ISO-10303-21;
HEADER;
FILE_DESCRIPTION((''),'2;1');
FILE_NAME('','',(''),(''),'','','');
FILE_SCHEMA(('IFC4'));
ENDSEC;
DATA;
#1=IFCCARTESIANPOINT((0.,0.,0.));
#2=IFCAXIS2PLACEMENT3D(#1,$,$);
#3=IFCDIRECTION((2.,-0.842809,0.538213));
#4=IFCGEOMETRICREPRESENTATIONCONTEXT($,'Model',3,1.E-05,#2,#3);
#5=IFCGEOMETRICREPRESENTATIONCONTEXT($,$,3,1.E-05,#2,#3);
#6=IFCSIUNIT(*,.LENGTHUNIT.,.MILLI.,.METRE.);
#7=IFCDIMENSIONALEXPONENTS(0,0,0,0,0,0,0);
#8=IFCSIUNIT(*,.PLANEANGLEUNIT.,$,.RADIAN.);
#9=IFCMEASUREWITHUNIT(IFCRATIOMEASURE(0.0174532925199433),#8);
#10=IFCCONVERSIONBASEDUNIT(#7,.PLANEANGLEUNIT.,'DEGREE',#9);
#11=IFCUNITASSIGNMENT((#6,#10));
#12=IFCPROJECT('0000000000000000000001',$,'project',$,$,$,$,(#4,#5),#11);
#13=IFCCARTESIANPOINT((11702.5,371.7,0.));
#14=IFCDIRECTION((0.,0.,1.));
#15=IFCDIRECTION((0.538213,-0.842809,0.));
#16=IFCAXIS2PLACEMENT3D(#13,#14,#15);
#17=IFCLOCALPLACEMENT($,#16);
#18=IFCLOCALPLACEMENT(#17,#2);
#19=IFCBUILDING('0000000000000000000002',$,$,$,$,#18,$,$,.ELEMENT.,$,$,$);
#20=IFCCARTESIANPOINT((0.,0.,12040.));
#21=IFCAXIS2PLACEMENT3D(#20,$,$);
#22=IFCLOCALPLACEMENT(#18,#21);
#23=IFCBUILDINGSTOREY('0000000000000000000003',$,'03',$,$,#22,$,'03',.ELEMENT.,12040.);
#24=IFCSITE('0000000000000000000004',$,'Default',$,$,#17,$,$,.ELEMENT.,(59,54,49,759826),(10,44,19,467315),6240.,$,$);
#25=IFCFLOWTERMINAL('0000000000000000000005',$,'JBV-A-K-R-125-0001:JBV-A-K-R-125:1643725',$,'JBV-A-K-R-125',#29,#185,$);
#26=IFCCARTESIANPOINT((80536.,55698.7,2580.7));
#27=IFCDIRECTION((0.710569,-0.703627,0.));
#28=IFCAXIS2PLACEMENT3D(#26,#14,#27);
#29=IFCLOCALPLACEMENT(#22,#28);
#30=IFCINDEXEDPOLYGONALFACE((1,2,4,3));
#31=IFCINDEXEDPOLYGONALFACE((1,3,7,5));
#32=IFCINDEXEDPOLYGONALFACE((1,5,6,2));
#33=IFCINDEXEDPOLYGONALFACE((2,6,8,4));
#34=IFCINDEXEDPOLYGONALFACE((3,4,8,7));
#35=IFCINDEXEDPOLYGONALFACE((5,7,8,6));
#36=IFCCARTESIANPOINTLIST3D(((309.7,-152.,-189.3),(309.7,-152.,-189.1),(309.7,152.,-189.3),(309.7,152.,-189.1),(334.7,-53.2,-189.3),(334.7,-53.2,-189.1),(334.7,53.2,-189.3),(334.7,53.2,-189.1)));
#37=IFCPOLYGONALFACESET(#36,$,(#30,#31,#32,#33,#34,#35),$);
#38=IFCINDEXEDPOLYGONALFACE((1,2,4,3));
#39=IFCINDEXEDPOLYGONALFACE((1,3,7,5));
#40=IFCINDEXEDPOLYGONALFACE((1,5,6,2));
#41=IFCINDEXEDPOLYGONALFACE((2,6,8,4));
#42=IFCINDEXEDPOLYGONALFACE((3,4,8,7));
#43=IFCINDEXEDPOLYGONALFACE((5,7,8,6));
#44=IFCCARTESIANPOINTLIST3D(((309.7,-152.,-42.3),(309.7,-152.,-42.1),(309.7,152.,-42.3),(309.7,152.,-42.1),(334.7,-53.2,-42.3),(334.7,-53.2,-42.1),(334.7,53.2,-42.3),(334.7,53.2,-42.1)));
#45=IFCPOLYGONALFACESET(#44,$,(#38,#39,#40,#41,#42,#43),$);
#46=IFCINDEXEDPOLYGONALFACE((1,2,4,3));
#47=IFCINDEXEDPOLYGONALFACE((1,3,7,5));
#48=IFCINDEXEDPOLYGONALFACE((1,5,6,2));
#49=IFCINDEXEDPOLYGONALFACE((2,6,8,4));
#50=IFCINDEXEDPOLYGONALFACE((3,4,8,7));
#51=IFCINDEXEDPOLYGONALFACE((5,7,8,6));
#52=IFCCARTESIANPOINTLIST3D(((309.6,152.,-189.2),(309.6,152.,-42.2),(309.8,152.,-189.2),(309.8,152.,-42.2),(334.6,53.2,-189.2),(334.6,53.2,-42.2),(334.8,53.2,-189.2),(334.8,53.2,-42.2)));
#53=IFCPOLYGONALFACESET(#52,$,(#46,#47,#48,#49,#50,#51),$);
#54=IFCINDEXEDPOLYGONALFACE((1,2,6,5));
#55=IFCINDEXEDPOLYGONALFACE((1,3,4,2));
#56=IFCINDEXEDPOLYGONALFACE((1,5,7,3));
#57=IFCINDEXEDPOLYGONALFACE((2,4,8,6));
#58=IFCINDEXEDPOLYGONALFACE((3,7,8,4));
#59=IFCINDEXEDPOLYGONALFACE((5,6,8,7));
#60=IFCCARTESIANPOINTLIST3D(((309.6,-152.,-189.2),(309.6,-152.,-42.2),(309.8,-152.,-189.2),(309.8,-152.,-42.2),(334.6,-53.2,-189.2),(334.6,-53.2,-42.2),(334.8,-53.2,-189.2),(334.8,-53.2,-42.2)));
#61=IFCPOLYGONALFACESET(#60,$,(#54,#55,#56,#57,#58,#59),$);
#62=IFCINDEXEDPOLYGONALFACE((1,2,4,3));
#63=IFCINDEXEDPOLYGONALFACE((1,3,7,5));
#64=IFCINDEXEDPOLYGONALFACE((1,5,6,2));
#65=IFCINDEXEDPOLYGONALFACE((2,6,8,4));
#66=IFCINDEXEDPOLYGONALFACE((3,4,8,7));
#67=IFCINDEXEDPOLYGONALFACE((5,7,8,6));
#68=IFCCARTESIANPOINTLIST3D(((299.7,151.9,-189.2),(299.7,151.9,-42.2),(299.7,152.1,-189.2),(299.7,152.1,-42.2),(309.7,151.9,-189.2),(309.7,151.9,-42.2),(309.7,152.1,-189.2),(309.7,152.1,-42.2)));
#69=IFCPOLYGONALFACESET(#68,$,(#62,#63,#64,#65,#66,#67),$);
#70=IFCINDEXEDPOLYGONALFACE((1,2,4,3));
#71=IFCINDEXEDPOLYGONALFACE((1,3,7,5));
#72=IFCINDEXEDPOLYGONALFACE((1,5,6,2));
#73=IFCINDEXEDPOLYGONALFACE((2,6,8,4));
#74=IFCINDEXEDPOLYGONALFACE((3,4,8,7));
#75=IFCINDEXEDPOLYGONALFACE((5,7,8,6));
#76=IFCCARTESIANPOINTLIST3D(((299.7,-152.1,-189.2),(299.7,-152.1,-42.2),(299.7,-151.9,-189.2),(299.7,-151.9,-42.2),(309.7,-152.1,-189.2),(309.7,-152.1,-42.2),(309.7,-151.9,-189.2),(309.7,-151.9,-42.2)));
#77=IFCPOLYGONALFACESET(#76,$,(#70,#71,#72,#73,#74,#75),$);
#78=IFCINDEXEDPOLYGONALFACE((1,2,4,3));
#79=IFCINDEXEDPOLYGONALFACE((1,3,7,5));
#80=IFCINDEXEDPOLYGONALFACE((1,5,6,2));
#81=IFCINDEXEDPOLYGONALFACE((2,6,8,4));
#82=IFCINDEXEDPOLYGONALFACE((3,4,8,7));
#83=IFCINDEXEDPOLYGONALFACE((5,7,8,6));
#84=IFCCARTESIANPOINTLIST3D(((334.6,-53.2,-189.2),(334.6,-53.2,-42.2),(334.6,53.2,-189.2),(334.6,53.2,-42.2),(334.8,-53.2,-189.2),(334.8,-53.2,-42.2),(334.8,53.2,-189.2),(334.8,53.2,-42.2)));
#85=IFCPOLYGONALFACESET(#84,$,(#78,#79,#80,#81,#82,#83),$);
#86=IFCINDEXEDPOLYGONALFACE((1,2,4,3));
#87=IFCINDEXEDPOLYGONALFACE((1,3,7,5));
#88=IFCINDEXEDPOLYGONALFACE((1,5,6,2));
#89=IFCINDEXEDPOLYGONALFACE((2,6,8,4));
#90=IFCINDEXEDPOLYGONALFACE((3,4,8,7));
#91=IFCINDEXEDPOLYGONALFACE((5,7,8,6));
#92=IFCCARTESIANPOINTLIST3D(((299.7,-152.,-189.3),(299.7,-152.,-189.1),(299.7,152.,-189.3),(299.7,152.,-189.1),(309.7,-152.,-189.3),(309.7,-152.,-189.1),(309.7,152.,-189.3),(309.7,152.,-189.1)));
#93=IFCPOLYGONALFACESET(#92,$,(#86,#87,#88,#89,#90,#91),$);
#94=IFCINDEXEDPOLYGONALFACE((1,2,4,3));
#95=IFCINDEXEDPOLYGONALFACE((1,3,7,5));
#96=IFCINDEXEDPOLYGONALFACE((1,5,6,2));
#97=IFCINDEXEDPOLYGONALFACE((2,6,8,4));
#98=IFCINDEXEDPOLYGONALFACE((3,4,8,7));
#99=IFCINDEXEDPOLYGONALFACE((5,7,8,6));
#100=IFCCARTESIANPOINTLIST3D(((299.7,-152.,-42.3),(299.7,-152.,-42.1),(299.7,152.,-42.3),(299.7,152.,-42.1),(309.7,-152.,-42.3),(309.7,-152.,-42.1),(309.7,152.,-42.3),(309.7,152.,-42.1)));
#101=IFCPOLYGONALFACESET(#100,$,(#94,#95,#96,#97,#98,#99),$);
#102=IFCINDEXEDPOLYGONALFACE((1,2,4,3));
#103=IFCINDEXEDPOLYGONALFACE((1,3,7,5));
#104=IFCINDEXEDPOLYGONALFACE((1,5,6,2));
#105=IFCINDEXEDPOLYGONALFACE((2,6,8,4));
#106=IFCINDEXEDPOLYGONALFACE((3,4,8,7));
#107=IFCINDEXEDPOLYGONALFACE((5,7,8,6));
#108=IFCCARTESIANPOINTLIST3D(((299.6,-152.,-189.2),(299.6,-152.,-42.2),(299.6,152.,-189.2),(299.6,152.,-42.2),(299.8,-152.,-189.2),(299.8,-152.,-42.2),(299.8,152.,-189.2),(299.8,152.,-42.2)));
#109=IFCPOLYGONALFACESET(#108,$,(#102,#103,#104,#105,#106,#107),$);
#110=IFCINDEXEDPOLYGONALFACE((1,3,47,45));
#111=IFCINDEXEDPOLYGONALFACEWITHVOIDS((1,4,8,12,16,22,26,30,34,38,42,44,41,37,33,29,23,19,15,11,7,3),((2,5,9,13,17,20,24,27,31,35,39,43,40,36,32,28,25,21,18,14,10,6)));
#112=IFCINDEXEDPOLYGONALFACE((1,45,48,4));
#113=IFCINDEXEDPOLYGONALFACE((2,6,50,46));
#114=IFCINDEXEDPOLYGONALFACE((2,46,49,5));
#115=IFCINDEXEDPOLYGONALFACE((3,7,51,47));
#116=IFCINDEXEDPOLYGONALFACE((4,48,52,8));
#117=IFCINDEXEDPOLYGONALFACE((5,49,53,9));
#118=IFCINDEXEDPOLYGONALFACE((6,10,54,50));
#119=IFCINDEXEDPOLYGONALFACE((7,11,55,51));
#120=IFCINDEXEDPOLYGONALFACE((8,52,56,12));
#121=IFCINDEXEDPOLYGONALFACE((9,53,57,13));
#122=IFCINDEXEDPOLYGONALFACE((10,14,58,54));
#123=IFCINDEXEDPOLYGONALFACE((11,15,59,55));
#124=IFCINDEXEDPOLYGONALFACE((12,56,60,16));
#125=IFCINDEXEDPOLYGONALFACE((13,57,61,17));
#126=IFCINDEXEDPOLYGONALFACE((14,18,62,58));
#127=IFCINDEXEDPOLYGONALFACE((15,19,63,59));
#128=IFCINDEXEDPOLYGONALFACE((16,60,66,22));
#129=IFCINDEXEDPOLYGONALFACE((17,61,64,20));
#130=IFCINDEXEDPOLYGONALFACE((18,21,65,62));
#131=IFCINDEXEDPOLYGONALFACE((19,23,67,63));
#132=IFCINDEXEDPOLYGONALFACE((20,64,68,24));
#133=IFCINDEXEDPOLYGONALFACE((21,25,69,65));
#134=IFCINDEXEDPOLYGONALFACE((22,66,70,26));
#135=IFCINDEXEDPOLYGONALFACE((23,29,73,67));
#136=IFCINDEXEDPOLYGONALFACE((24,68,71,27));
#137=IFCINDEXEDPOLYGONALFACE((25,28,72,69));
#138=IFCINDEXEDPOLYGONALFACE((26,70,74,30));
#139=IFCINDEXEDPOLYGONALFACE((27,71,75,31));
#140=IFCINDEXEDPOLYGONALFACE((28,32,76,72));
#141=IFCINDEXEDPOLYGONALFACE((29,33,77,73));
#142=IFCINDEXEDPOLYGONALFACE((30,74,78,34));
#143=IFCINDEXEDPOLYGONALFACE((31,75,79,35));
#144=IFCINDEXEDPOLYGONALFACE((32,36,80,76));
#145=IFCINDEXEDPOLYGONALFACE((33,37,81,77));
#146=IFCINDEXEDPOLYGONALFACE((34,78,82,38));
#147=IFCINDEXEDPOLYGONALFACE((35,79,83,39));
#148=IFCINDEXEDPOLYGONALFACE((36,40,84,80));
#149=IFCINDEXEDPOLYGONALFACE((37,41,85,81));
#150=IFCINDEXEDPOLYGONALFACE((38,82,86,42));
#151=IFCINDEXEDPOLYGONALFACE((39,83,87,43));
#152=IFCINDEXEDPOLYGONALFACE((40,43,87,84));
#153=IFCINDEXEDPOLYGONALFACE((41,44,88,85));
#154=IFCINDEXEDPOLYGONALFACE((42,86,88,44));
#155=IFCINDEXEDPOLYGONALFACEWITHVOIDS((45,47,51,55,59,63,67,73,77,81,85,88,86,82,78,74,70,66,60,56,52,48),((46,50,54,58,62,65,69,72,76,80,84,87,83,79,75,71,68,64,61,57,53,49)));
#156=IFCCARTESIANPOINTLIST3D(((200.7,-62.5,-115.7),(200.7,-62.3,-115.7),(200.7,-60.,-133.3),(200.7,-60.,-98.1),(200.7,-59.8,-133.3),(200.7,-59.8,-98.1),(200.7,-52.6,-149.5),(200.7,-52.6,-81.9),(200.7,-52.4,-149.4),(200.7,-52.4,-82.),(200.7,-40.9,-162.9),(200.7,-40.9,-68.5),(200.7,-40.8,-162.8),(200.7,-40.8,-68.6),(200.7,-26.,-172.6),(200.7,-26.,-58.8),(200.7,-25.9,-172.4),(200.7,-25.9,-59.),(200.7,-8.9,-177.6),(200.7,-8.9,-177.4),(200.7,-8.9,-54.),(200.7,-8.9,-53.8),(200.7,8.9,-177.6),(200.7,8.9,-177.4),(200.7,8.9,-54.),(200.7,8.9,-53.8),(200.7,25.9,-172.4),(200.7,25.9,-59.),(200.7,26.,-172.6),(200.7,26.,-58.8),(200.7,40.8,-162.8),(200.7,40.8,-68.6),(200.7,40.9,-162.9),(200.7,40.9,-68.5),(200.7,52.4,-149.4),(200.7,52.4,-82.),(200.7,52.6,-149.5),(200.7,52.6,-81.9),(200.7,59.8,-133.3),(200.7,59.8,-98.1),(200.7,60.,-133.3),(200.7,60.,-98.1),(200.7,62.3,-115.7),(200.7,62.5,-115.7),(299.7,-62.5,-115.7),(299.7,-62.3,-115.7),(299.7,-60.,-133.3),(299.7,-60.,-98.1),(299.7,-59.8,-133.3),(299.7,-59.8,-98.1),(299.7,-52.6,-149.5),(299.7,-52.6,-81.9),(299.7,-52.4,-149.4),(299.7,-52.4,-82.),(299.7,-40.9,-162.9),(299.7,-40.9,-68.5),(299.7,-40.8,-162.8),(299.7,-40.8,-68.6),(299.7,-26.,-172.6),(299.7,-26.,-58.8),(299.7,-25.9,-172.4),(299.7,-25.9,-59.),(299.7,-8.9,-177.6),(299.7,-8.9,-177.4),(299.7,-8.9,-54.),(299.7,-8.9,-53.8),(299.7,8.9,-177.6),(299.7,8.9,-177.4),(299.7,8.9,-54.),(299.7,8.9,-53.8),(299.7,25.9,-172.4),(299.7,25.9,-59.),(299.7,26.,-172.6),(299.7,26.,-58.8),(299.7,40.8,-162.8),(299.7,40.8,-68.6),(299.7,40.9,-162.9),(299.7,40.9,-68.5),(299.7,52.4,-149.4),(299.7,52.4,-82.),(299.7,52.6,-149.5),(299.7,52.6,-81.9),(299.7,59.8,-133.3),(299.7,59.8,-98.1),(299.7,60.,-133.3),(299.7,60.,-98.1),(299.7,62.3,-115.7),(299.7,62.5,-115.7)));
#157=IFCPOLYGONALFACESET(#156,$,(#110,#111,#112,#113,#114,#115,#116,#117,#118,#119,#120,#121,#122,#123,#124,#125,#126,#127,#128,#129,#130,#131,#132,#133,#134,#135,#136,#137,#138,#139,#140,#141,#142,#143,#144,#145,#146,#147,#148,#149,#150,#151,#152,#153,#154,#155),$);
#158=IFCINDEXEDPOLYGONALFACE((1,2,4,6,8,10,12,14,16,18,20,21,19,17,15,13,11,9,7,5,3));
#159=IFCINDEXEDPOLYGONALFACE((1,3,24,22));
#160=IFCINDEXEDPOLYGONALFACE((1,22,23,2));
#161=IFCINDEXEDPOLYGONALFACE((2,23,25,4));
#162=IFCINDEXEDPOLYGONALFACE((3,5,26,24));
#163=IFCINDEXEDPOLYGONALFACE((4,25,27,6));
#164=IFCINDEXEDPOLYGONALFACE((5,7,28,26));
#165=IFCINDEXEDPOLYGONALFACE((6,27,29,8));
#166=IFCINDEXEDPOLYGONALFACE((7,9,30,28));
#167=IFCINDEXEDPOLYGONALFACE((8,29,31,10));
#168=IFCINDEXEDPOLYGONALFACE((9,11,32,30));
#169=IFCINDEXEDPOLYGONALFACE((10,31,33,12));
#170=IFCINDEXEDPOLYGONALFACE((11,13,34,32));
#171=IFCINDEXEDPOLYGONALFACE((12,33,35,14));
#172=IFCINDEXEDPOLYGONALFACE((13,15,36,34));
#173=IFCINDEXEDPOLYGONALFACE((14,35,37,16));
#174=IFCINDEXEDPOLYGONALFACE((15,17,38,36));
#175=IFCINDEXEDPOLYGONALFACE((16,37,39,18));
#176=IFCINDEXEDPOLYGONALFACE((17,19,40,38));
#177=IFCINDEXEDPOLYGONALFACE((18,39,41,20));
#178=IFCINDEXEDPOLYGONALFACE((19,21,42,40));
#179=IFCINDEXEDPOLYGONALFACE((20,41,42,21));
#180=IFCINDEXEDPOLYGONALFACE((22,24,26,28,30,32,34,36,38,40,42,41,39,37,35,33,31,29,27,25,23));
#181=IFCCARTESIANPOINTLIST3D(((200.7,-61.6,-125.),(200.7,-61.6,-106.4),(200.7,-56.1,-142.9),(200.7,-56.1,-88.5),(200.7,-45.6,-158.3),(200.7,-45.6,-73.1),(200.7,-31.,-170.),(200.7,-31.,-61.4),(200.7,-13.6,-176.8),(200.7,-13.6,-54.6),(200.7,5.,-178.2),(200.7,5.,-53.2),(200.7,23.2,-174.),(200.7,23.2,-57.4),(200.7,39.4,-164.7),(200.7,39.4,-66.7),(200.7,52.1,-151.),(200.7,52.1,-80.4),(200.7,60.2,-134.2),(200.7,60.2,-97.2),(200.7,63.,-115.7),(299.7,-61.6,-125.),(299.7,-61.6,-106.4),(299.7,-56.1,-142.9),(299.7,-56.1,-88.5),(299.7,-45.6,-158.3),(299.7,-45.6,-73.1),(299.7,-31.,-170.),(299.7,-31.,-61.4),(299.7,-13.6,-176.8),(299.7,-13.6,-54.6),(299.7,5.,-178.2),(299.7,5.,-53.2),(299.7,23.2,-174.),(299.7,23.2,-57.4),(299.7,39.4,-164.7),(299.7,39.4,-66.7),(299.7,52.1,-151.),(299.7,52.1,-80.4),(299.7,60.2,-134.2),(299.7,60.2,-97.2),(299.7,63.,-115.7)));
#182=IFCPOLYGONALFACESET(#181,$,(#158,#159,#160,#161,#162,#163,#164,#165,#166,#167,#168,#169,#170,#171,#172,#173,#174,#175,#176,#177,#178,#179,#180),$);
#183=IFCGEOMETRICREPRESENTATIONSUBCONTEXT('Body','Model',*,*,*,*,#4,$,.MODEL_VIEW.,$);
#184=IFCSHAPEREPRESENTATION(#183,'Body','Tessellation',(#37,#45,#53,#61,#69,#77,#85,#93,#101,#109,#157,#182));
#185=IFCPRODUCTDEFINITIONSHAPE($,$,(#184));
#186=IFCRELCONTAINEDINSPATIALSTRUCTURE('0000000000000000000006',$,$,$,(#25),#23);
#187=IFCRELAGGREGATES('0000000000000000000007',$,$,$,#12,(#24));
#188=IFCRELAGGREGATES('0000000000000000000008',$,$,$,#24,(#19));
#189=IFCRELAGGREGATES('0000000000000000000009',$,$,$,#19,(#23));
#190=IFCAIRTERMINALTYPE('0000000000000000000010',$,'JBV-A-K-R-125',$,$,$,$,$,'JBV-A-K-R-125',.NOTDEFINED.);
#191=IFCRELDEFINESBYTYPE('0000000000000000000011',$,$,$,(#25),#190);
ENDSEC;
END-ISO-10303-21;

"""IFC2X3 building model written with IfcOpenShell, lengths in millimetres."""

from ifc_helpers import new_model, entity, si_unit, converted_unit, direction, frame, frame_2d, origin, origin_2d_with_axis, place, context, subcontext, project, spatial, polyline, circle_curve, parameter, trimmed, segment, composite_curve, rectangle, circle, outline, extrude, source, transform, mapped, type_object, type_shapes, element, save


model = new_model("IFC2X3")

# Units and contexts
model_context = context("Model", 3, precision=1e-05, world=origin(), true_north=direction((2.0, -0.842809, 0.538213)))
context_of_model = context(None, 3, precision=1e-05, world=origin(), true_north=direction((2.0, -0.842809, 0.538213)))
body_context = subcontext(model_context, "Body", "Model", "MODEL_VIEW")
ifc_project = project(units=[si_unit("LENGTHUNIT", "METRE", prefix="MILLI"), converted_unit("PLANEANGLEUNIT", "DEGREE", entity("IfcRatioMeasure", 0.0174532925199433), si_unit("PLANEANGLEUNIT", "RADIAN"), dimensions=[0, 0, 0, 0, 0, 0, 0])], contexts=[model_context, context_of_model])

# Site, building, storey
site_placement = place(None, frame((11702.5, 371.7, 0.0), z_axis=(0.0, 0.0, 1.0), x_axis=(0.538213, -0.842809, 0.0)))
site = spatial("IfcSite", under=ifc_project, at=site_placement, Name="Default", CompositionType="ELEMENT", RefLatitude=(59, 54, 49, 759826), RefLongitude=(10, 44, 19, 467315), RefElevation=6240.0)
building_placement = place(site_placement, origin())
building = spatial("IfcBuilding", under=site, at=building_placement, CompositionType="ELEMENT")
storey_placement = place(building_placement, frame((0.0, 0.0, 12040.0)))
storey = spatial("IfcBuildingStorey", under=building, at=storey_placement, Name="03", LongName="03", CompositionType="ELEMENT", Elevation=12040.0)

# Flow terminal
air_terminal_type_1 = type_object("IfcAirTerminalType", Name="JBV-A-K-R-125", ElementType="JBV-A-K-R-125", PredefinedType="NOTDEFINED")
shared_shape_1 = source(origin(), body_context, "Body", "SweptSolid", [
    extrude(outline(polyline([(-152.0, -12.5), (152.0, -12.5), (53.2, 12.5), (-53.2, 12.5), (-152.0, -12.5)])), frame((322.2, 0.0, -189.3), z_axis=(0.0, 0.0, 1.0), x_axis=(0.0, -1.0, 0.0)), (0.0, 0.0, 1.0), 0.2),
    extrude(outline(polyline([(-152.0, -12.5), (152.0, -12.5), (53.2, 12.5), (-53.2, 12.5), (-152.0, -12.5)])), frame((322.2, 0.0, -42.3), z_axis=(0.0, 0.0, 1.0), x_axis=(0.0, -1.0, 0.0)), (0.0, 0.0, 1.0), 0.2),
    extrude(rectangle(XDim=0.2, YDim=101.9, at=frame_2d((0.0, 0.0), x_axis=(1.0, 0.0))), frame((322.2, 102.6, -189.2), z_axis=(0.0, 0.0, 1.0), x_axis=(0.969446, 0.245305, 0.0)), (0.0, 0.0, 1.0), 147.0),
    extrude(rectangle(XDim=0.2, YDim=101.9, at=frame_2d((0.0, 0.0), x_axis=(1.0, 0.0))), frame((322.2, -102.6, -189.2), z_axis=(0.0, 0.0, 1.0), x_axis=(-0.969446, 0.245305, 0.0)), (0.0, 0.0, 1.0), 147.0),
    extrude(rectangle(XDim=0.2, YDim=10.0, at=frame_2d((0.0, 0.0), x_axis=(1.0, 0.0))), frame((304.7, 152.0, -189.2), z_axis=(0.0, 0.0, 1.0), x_axis=(0.0, 1.0, 0.0)), (0.0, 0.0, 1.0), 147.0),
    extrude(rectangle(XDim=0.2, YDim=10.0, at=frame_2d((0.0, 0.0), x_axis=(1.0, 0.0))), frame((304.7, -152.0, -189.2), z_axis=(0.0, 0.0, 1.0), x_axis=(0.0, 1.0, 0.0)), (0.0, 0.0, 1.0), 147.0),
    extrude(rectangle(XDim=0.2, YDim=106.4, at=frame_2d((0.0, 0.0), x_axis=(1.0, 0.0))), frame((334.7, 0.0, -189.2)), (0.0, 0.0, 1.0), 147.0),
    extrude(rectangle(XDim=304.0, YDim=10.0, at=frame_2d((0.0, 0.0), x_axis=(1.0, 0.0))), frame((304.7, 0.0, -189.3), z_axis=(0.0, 0.0, 1.0), x_axis=(0.0, -1.0, 0.0)), (0.0, 0.0, 1.0), 0.2),
    extrude(rectangle(XDim=304.0, YDim=10.0, at=frame_2d((0.0, 0.0), x_axis=(1.0, 0.0))), frame((304.7, 0.0, -42.3), z_axis=(0.0, 0.0, 1.0), x_axis=(0.0, -1.0, 0.0)), (0.0, 0.0, 1.0), 0.2),
    extrude(rectangle(XDim=0.2, YDim=304.0, at=frame_2d((0.0, 0.0), x_axis=(1.0, 0.0))), frame((299.7, 0.0, -189.2)), (0.0, 0.0, 1.0), 147.0),
    extrude(outline(composite_curve([segment(trimmed(circle_curve(origin_2d_with_axis(), 62.5), [parameter(0.0)], [parameter(180.0)], True, "PARAMETER"), True, "CONTINUOUS"), segment(trimmed(circle_curve(origin_2d_with_axis(), 62.5), [parameter(180.0)], [parameter(360.0)], True, "PARAMETER"), True, "CONTINUOUS")], self_intersect=False), holes=[composite_curve([segment(trimmed(circle_curve(origin_2d_with_axis(), 62.3), [parameter(180.0)], [parameter(360.0)], True, "PARAMETER"), False, "CONTINUOUS"), segment(trimmed(circle_curve(origin_2d_with_axis(), 62.3), [parameter(0.0)], [parameter(180.0)], True, "PARAMETER"), False, "CONTINUOUS")], self_intersect=False)]), frame((200.7, 0.0, -115.7), z_axis=(1.0, 0.0, 0.0), x_axis=(0.0, 1.0, 0.0)), (0.0, 0.0, 1.0), 99.0),
    extrude(circle(Radius=62.6, at=frame_2d((0.0, 0.0), x_axis=(1.0, 0.0))), frame((200.7, 0.3, -115.7), z_axis=(1.0, 0.0, 0.0), x_axis=(0.0, 1.0, 0.0)), (0.0, 0.0, 1.0), 99.0),
])
type_shapes(air_terminal_type_1, [shared_shape_1])
for number, where, z_axis, x_axis, name in (
    (1, (80536.0, 55698.7, 2580.7), (0.0, 0.0, 1.0), (0.710569, -0.703627, 0.0), "JBV-A-K-R-125-0001:JBV-A-K-R-125:1643725"),
):
    element("IfcFlowTerminal", number, at=place(storey_placement, frame(where, z_axis=z_axis, x_axis=x_axis)), inside=storey, type_object=air_terminal_type_1, Name=name, ObjectType="JBV-A-K-R-125", context=body_context, shape_type="MappedRepresentation", body=[
        mapped(shared_shape_1, transform((0.0, 0.0, 0.0), scale=1.0)),
    ])

save(model, "model.ifc")
